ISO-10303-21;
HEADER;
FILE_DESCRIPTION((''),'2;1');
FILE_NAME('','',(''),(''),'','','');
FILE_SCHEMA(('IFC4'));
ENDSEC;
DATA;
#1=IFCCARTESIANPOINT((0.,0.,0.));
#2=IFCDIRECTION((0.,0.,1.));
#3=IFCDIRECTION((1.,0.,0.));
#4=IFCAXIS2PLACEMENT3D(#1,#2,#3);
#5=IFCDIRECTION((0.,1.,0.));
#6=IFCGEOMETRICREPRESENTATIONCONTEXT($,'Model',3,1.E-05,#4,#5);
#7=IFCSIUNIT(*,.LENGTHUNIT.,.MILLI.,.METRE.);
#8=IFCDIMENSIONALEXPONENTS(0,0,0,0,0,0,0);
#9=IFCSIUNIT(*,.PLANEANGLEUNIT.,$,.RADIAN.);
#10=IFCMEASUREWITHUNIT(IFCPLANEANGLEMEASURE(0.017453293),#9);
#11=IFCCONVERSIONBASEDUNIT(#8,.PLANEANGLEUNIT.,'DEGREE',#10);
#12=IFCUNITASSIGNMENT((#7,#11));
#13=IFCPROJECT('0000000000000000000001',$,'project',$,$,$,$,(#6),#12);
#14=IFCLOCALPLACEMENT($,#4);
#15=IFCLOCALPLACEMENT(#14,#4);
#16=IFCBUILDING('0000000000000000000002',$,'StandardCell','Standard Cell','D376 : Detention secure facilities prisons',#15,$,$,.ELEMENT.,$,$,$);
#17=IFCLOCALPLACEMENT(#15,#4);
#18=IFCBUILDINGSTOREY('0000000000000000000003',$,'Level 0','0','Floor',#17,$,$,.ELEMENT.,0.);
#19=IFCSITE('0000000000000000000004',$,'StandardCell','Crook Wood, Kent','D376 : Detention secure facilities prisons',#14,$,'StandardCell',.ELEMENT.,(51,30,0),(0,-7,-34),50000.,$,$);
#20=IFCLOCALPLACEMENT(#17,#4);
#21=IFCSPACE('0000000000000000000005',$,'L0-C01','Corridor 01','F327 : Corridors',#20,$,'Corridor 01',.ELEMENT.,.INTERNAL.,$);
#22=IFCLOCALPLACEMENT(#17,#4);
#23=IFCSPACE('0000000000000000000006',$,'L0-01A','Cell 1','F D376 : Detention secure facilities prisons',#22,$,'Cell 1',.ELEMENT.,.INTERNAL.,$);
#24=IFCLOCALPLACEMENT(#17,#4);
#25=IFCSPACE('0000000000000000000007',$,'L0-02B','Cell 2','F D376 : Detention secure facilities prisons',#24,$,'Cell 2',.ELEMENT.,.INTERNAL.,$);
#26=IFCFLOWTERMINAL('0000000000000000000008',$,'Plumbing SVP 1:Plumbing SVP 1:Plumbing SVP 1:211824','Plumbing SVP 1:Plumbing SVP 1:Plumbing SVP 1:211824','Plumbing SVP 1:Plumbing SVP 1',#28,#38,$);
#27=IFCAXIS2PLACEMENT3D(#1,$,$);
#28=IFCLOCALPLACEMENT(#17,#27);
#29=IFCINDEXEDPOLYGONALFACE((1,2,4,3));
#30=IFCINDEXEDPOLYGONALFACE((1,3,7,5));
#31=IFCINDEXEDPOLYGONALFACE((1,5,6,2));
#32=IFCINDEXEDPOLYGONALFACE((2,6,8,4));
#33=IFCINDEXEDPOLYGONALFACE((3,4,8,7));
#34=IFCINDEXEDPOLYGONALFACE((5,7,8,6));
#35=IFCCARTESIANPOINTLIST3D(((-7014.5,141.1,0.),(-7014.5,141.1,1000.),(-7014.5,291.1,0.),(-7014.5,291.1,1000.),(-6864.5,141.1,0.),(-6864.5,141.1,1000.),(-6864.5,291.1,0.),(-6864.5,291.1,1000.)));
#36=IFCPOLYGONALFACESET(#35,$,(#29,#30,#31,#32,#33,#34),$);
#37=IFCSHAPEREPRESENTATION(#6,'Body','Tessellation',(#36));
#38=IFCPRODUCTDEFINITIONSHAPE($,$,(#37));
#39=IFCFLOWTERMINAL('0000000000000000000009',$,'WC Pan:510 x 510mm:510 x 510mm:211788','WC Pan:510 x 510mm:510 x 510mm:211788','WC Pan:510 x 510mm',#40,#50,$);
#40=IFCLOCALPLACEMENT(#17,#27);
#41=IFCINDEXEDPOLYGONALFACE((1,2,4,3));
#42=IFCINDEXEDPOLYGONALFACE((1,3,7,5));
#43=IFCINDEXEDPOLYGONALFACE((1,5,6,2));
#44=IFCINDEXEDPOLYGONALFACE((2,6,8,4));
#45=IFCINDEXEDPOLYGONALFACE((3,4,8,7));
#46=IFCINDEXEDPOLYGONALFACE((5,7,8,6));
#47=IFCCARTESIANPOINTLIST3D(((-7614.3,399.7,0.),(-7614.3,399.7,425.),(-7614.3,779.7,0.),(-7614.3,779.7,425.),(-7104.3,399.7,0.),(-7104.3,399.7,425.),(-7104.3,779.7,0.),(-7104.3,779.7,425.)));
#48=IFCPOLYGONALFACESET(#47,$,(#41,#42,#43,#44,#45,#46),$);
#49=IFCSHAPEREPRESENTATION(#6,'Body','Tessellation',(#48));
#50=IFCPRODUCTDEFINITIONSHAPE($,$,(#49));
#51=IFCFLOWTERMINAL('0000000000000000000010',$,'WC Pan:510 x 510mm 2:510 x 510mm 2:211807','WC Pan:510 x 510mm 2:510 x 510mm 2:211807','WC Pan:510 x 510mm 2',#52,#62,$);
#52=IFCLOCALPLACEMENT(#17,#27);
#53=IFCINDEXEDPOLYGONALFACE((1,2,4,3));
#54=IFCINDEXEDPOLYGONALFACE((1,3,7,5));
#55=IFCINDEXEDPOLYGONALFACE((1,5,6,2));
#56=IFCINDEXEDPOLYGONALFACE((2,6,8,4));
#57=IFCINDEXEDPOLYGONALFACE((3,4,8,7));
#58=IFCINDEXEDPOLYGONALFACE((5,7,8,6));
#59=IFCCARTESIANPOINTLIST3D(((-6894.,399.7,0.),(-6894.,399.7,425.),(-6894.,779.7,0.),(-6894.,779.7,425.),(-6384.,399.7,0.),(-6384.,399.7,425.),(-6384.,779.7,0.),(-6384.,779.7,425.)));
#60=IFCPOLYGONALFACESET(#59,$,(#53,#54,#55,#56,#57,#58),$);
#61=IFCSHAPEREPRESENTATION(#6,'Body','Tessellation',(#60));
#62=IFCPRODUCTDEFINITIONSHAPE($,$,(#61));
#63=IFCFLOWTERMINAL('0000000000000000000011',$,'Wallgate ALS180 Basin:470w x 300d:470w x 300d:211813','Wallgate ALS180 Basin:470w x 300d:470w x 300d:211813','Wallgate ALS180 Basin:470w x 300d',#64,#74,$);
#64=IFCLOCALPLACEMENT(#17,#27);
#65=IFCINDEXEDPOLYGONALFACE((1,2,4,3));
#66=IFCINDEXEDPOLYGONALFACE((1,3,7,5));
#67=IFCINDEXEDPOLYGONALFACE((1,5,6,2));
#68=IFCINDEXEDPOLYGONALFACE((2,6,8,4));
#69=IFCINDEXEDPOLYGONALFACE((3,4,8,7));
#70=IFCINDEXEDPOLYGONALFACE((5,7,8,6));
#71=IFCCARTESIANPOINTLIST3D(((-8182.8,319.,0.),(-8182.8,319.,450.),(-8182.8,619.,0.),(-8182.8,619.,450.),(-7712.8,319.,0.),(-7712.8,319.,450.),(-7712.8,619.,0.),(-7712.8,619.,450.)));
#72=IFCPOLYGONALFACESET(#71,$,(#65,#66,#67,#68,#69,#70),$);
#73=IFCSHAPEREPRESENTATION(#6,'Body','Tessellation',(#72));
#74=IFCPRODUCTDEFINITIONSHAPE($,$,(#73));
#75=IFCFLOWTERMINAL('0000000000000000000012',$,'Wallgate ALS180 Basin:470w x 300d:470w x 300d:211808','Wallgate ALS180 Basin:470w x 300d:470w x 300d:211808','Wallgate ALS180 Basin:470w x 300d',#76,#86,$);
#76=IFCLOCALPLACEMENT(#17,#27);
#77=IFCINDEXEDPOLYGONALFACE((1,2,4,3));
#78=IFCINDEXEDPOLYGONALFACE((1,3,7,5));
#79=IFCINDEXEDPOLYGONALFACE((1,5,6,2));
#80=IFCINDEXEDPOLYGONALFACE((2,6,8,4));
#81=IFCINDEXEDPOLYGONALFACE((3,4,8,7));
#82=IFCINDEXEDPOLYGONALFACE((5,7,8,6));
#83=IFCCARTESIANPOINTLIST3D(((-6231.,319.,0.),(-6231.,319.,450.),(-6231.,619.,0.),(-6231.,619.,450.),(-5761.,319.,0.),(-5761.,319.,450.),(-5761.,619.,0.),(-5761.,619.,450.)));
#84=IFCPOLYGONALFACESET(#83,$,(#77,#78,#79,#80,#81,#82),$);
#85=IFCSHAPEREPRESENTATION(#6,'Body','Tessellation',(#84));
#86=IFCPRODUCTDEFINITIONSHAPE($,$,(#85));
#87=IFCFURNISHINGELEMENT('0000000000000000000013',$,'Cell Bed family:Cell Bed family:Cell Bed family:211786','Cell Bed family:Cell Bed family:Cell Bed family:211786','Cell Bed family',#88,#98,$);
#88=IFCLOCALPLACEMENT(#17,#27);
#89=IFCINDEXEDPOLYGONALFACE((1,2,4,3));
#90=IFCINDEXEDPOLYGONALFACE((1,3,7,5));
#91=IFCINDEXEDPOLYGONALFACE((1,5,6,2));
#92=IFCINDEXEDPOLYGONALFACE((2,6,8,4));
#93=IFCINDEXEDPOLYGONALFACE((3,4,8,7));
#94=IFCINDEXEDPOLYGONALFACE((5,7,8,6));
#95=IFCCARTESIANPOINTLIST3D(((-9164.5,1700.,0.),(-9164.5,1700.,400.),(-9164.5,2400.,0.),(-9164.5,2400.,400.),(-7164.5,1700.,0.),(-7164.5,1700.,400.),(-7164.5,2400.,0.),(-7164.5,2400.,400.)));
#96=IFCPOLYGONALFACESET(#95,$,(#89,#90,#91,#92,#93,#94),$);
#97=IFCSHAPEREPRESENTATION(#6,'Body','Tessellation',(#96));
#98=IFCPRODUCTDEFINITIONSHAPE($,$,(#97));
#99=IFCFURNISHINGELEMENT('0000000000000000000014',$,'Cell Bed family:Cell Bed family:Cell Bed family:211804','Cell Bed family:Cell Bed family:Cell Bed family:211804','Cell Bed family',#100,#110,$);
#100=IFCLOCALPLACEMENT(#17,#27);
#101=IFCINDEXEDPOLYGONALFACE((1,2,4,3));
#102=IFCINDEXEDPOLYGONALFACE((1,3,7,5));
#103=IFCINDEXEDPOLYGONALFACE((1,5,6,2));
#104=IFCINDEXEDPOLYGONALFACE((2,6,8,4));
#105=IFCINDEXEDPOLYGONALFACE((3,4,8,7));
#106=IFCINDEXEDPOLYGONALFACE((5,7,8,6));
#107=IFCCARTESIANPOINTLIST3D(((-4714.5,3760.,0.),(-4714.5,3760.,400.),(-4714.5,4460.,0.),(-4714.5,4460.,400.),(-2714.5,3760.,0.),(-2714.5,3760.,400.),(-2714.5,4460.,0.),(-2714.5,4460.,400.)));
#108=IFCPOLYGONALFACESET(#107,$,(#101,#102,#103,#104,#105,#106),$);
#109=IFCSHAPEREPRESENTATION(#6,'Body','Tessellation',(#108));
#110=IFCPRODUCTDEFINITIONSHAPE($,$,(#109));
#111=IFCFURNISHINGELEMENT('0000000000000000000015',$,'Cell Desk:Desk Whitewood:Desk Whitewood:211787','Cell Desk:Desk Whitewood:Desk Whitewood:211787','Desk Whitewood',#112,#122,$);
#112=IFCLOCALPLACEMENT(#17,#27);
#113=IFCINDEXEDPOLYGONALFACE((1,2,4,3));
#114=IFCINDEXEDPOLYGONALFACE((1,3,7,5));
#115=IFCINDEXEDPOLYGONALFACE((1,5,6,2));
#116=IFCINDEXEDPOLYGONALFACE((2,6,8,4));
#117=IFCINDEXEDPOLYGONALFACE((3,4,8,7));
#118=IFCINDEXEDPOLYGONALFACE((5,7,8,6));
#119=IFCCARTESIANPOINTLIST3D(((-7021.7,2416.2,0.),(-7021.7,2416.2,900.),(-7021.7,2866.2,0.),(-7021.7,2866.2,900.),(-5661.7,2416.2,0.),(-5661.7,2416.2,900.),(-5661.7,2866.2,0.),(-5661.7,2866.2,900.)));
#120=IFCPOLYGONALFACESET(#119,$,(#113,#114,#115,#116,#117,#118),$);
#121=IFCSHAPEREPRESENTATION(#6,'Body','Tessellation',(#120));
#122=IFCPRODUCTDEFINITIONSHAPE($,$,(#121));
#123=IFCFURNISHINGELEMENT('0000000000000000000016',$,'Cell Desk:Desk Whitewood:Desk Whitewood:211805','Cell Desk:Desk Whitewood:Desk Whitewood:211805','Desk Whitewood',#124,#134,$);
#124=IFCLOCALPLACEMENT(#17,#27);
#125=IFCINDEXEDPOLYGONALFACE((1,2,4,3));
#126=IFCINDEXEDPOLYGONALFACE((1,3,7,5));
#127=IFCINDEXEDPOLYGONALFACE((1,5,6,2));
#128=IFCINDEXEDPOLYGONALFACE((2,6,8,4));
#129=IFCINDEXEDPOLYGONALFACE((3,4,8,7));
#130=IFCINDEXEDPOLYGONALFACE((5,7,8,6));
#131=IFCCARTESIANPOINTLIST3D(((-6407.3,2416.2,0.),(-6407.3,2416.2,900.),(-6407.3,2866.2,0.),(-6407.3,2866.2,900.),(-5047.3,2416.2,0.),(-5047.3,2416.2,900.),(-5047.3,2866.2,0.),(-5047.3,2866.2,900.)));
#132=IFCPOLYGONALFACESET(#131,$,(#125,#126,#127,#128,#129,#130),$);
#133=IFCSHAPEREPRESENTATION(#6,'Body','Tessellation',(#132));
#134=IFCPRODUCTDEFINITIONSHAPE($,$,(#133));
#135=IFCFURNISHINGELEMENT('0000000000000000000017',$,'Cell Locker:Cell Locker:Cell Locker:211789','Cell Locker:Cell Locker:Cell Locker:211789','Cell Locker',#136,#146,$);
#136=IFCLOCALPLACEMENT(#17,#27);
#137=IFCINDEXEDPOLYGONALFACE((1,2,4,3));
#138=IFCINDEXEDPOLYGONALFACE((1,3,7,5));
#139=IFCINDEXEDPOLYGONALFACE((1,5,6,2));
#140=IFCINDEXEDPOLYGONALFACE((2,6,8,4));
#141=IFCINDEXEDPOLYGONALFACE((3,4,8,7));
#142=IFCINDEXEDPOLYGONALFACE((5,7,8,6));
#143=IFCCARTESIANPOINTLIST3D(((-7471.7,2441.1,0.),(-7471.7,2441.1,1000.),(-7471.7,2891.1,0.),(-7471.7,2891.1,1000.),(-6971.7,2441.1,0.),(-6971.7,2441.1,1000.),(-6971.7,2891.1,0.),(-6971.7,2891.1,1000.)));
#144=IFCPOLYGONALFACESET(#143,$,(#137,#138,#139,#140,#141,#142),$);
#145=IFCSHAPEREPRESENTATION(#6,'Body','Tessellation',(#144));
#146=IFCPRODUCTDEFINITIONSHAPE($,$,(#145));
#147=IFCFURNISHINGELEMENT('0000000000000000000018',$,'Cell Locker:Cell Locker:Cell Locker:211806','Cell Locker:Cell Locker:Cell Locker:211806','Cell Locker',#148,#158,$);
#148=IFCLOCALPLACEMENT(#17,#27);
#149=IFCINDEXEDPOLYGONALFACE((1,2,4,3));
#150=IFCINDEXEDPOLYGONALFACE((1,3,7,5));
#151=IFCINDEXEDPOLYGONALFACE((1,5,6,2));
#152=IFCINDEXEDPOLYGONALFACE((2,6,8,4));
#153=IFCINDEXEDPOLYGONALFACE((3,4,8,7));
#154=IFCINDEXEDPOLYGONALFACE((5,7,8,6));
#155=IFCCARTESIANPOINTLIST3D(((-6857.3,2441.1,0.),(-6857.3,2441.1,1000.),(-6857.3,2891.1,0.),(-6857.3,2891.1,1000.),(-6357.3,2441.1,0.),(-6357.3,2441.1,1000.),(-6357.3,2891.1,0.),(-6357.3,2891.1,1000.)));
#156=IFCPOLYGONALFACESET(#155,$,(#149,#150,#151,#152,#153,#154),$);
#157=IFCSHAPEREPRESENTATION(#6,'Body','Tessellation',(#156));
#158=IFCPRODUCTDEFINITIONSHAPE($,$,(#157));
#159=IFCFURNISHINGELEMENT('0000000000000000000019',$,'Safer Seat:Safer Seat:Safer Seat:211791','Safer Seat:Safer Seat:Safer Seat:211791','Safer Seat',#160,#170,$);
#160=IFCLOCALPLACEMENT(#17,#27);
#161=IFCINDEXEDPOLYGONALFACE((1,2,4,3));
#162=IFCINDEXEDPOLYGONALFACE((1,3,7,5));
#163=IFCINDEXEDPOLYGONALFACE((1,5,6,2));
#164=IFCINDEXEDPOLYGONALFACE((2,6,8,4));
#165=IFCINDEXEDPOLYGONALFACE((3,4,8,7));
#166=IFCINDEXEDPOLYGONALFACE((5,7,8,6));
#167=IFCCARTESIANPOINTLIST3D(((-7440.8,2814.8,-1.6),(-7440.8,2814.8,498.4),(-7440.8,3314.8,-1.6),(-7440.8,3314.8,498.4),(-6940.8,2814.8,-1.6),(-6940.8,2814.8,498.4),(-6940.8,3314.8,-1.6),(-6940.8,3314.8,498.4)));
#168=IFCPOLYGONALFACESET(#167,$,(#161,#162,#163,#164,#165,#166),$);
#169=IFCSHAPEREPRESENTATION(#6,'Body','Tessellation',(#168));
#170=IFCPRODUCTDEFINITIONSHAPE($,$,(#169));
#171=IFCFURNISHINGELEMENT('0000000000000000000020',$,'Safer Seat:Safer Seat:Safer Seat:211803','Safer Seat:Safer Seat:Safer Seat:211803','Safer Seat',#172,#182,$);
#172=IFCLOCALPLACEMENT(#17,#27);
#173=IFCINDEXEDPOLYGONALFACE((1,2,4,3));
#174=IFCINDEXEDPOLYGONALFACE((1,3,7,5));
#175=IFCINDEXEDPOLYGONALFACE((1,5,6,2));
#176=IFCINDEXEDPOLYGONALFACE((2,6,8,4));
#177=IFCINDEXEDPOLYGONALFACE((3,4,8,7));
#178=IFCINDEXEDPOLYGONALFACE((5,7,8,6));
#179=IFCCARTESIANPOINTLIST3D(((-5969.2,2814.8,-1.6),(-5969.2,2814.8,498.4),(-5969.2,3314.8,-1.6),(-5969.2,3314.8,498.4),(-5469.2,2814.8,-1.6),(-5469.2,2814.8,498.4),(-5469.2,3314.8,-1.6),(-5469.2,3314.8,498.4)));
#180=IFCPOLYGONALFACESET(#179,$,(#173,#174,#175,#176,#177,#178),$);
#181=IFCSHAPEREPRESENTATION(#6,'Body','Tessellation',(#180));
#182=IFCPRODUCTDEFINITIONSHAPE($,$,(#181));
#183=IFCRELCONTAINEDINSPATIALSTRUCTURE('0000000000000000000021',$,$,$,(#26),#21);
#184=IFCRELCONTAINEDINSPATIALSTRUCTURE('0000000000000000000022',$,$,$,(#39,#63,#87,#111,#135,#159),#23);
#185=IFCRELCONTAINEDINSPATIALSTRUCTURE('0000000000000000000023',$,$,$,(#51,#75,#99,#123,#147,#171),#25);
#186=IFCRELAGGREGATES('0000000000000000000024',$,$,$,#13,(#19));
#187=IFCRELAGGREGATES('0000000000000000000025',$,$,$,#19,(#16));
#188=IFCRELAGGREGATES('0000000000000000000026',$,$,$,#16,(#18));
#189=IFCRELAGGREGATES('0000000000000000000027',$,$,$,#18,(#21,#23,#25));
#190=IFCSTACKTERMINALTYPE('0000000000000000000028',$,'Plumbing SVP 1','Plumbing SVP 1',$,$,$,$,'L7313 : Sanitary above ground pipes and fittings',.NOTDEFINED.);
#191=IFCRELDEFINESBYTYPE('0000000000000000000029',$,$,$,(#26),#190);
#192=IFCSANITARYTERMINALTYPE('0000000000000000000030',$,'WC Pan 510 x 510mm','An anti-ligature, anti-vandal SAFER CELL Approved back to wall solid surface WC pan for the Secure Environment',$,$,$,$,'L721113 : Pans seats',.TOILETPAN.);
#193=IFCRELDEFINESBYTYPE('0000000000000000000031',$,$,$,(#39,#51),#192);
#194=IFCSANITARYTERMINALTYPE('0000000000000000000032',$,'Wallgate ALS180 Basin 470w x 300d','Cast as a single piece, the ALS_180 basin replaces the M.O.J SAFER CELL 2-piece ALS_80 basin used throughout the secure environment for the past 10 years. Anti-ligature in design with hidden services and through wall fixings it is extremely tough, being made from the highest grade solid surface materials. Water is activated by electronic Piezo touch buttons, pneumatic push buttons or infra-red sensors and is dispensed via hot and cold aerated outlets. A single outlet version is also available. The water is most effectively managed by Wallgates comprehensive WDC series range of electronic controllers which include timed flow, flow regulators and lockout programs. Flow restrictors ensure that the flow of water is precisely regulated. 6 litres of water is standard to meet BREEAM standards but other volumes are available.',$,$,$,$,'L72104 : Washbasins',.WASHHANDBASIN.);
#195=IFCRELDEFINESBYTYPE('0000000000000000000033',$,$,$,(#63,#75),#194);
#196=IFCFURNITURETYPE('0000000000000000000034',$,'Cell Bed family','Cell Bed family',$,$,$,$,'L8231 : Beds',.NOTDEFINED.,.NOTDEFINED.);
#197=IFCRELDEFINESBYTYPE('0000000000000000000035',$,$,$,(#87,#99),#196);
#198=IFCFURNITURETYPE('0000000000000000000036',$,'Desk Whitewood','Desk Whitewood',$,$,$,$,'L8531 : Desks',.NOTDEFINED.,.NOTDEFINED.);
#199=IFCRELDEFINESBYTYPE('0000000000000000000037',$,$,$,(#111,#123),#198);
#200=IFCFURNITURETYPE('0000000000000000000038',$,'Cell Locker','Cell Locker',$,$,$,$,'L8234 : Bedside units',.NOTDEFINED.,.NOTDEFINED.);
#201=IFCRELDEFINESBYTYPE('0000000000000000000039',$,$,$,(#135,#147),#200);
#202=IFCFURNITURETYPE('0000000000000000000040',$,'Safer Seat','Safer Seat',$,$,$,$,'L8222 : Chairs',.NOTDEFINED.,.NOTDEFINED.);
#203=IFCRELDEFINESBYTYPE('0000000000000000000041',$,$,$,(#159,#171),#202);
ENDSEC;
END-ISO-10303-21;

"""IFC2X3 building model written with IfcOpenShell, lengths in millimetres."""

from ifc_helpers import new_model, entity, si_unit, converted_unit, direction, frame, frame_2d, origin, origin_with_axes, place, context, project, spatial, rectangle, extrude, source, transform, mapped, type_object, type_shapes, element, save


model = new_model("IFC2X3")

# Units and contexts
model_context = context("Model", 3, precision=1e-05, world=origin_with_axes(), true_north=direction((0.0, 1.0, 0.0)))
ifc_project = project(units=[si_unit("LENGTHUNIT", "METRE", prefix="MILLI"), converted_unit("PLANEANGLEUNIT", "DEGREE", entity("IfcPlaneAngleMeasure", 0.017453293), si_unit("PLANEANGLEUNIT", "RADIAN"), dimensions=[0, 0, 0, 0, 0, 0, 0])], contexts=[model_context])

# Site, building, storey, space
site_placement = place(None, origin_with_axes())
site = spatial("IfcSite", under=ifc_project, at=site_placement, Name="StandardCell", Description="Crook Wood, Kent", ObjectType="D376 : Detention secure facilities prisons", LongName="StandardCell", CompositionType="ELEMENT", RefLatitude=(51, 30, 0), RefLongitude=(0, -7, -34), RefElevation=50000.0)
building_placement = place(site_placement, origin_with_axes())
building = spatial("IfcBuilding", under=site, at=building_placement, Name="StandardCell", Description="Standard Cell", ObjectType="D376 : Detention secure facilities prisons", CompositionType="ELEMENT")
storey_placement = place(building_placement, origin_with_axes())
storey = spatial("IfcBuildingStorey", under=building, at=storey_placement, Name="Level 0", Description="0", ObjectType="Floor", CompositionType="ELEMENT", Elevation=0.0)
space_1_placement = place(storey_placement, origin_with_axes())
space_1 = spatial("IfcSpace", under=storey, at=space_1_placement, Name="L0-C01", Description="Corridor 01", ObjectType="F327 : Corridors", LongName="Corridor 01", CompositionType="ELEMENT", InteriorOrExteriorSpace="INTERNAL")

# Shared definitions
space_2_placement = place(storey_placement, origin_with_axes())
space_2 = spatial("IfcSpace", under=storey, at=space_2_placement, Name="L0-01A", Description="Cell 1", ObjectType="F D376 : Detention secure facilities prisons", LongName="Cell 1", CompositionType="ELEMENT", InteriorOrExteriorSpace="INTERNAL")

# Shared definitions
space_3_placement = place(storey_placement, origin_with_axes())
space_3 = spatial("IfcSpace", under=storey, at=space_3_placement, Name="L0-02B", Description="Cell 2", ObjectType="F D376 : Detention secure facilities prisons", LongName="Cell 2", CompositionType="ELEMENT", InteriorOrExteriorSpace="INTERNAL")

# Flow terminals
stack_terminal_type = type_object("IfcStackTerminalType", Name="Plumbing SVP 1", Description="Plumbing SVP 1", ElementType="L7313 : Sanitary above ground pipes and fittings", PredefinedType="NOTDEFINED")
shared_shape_1 = source(origin(), model_context, "Body", "SweptSolid", [
    extrude(rectangle(XDim=150.0, YDim=150.0, at=frame_2d((75.0, 75.0), x_axis=(1.0, 0.0))), origin_with_axes(), (0.0, 0.0, 1.0), 1000.0),
])
type_shapes(stack_terminal_type, [shared_shape_1])
flow_terminal_1_placement = place(space_1_placement, frame((-7014.5, 141.1, 0.0), z_axis=(0.0, 0.0, 1.0), x_axis=(1.0, 0.0, 0.0)))
element("IfcFlowTerminal", 1, at=flow_terminal_1_placement, inside=space_1, type_object=stack_terminal_type, Name="Plumbing SVP 1:Plumbing SVP 1:Plumbing SVP 1:211824", Description="Plumbing SVP 1:Plumbing SVP 1:Plumbing SVP 1:211824", ObjectType="Plumbing SVP 1:Plumbing SVP 1", context=model_context, shape_type="MappedRepresentation", body=[
    mapped(shared_shape_1, transform((0.0, 0.0, 0.0))),
])
sanitary_terminal_type_1 = type_object("IfcSanitaryTerminalType", Name="WC Pan 510 x 510mm", Description="An anti-ligature, anti-vandal SAFER CELL Approved back to wall solid surface WC pan for the Secure Environment", ElementType="L721113 : Pans seats", PredefinedType="TOILETPAN")
shared_shape_2 = source(origin(), model_context, "Body", "SweptSolid", [
    extrude(rectangle(XDim=510.0, YDim=380.0, at=frame_2d((255.0, 190.0), x_axis=(1.0, 0.0))), origin_with_axes(), (0.0, 0.0, 1.0), 425.0),
])
type_shapes(sanitary_terminal_type_1, [shared_shape_2])
flow_terminal_2_placement = place(space_2_placement, frame((-7614.3, 399.7, 0.0), z_axis=(0.0, 0.0, 1.0), x_axis=(1.0, 0.0, 0.0)))
element("IfcFlowTerminal", 2, at=flow_terminal_2_placement, inside=space_2, type_object=sanitary_terminal_type_1, Name="WC Pan:510 x 510mm:510 x 510mm:211788", Description="WC Pan:510 x 510mm:510 x 510mm:211788", ObjectType="WC Pan:510 x 510mm", context=model_context, shape_type="MappedRepresentation", body=[
    mapped(shared_shape_2, transform((0.0, 0.0, 0.0))),
])
flow_terminal_3_placement = place(space_3_placement, frame((-6894.0, 399.7, 0.0), z_axis=(0.0, 0.0, 1.0), x_axis=(1.0, 0.0, 0.0)))
element("IfcFlowTerminal", 3, at=flow_terminal_3_placement, inside=space_3, type_object=sanitary_terminal_type_1, Name="WC Pan:510 x 510mm 2:510 x 510mm 2:211807", Description="WC Pan:510 x 510mm 2:510 x 510mm 2:211807", ObjectType="WC Pan:510 x 510mm 2", context=model_context, shape_type="MappedRepresentation", body=[
    mapped(shared_shape_2, transform((0.0, 0.0, 0.0))),
])
sanitary_terminal_type_2 = type_object("IfcSanitaryTerminalType", Name="Wallgate ALS180 Basin 470w x 300d", Description="Cast as a single piece, the ALS_180 basin replaces the M.O.J SAFER CELL 2-piece ALS_80 basin used throughout the secure environment for the past 10 years. Anti-ligature in design with hidden services and through wall fixings it is extremely tough, being made from the highest grade solid surface materials. Water is activated by electronic Piezo touch buttons, pneumatic push buttons or infra-red sensors and is dispensed via hot and cold aerated outlets. A single outlet version is also available. The water is most effectively managed by Wallgates comprehensive WDC series range of electronic controllers which include timed flow, flow regulators and lockout programs. Flow restrictors ensure that the flow of water is precisely regulated. 6 litres of water is standard to meet BREEAM standards but other volumes are available.", ElementType="L72104 : Washbasins", PredefinedType="WASHHANDBASIN")
shared_shape_3 = source(origin(), model_context, "Body", "SweptSolid", [
    extrude(rectangle(XDim=470.0, YDim=300.0, at=frame_2d((235.0, 150.0), x_axis=(1.0, 0.0))), origin_with_axes(), (0.0, 0.0, 1.0), 450.0),
])
type_shapes(sanitary_terminal_type_2, [shared_shape_3])
flow_terminal_4_placement = place(space_2_placement, frame((-8182.8, 319.0, 0.0), z_axis=(0.0, 0.0, 1.0), x_axis=(1.0, 0.0, 0.0)))
element("IfcFlowTerminal", 4, at=flow_terminal_4_placement, inside=space_2, type_object=sanitary_terminal_type_2, Name="Wallgate ALS180 Basin:470w x 300d:470w x 300d:211813", Description="Wallgate ALS180 Basin:470w x 300d:470w x 300d:211813", ObjectType="Wallgate ALS180 Basin:470w x 300d", context=model_context, shape_type="MappedRepresentation", body=[
    mapped(shared_shape_3, transform((0.0, 0.0, 0.0))),
])
flow_terminal_5_placement = place(space_3_placement, frame((-6231.0, 319.0, 0.0), z_axis=(0.0, 0.0, 1.0), x_axis=(1.0, 0.0, 0.0)))
element("IfcFlowTerminal", 5, at=flow_terminal_5_placement, inside=space_3, type_object=sanitary_terminal_type_2, Name="Wallgate ALS180 Basin:470w x 300d:470w x 300d:211808", Description="Wallgate ALS180 Basin:470w x 300d:470w x 300d:211808", ObjectType="Wallgate ALS180 Basin:470w x 300d", context=model_context, shape_type="MappedRepresentation", body=[
    mapped(shared_shape_3, transform((0.0, 0.0, 0.0))),
])

# Furnishing elements
furniture_type_1 = type_object("IfcFurnitureType", Name="Cell Bed family", Description="Cell Bed family", ElementType="L8231 : Beds", AssemblyPlace="NOTDEFINED")
shared_shape_4 = source(origin(), model_context, "Body", "SweptSolid", [
    extrude(rectangle(XDim=2000.0, YDim=700.0, at=frame_2d((1000.0, 350.0), x_axis=(1.0, 0.0))), origin_with_axes(), (0.0, 0.0, 1.0), 400.0),
])
type_shapes(furniture_type_1, [shared_shape_4])
furnishing_1_placement = place(space_2_placement, frame((-9164.5, 1700.0, 0.0), z_axis=(0.0, 0.0, 1.0), x_axis=(1.0, 0.0, 0.0)))
element("IfcFurnishingElement", 6, at=furnishing_1_placement, inside=space_2, type_object=furniture_type_1, Name="Cell Bed family:Cell Bed family:Cell Bed family:211786", Description="Cell Bed family:Cell Bed family:Cell Bed family:211786", ObjectType="Cell Bed family", context=model_context, shape_type="MappedRepresentation", body=[
    mapped(shared_shape_4, transform((0.0, 0.0, 0.0))),
])
furnishing_2_placement = place(space_3_placement, frame((-4714.5, 3760.0, 0.0), z_axis=(0.0, 0.0, 1.0), x_axis=(1.0, 0.0, 0.0)))
element("IfcFurnishingElement", 7, at=furnishing_2_placement, inside=space_3, type_object=furniture_type_1, Name="Cell Bed family:Cell Bed family:Cell Bed family:211804", Description="Cell Bed family:Cell Bed family:Cell Bed family:211804", ObjectType="Cell Bed family", context=model_context, shape_type="MappedRepresentation", body=[
    mapped(shared_shape_4, transform((0.0, 0.0, 0.0))),
])
furniture_type_2 = type_object("IfcFurnitureType", Name="Desk Whitewood", Description="Desk Whitewood", ElementType="L8531 : Desks", AssemblyPlace="NOTDEFINED")
shared_shape_5 = source(origin(), model_context, "Body", "SweptSolid", [
    extrude(rectangle(XDim=1360.0, YDim=450.0, at=frame_2d((680.0, 225.0), x_axis=(1.0, 0.0))), origin_with_axes(), (0.0, 0.0, 1.0), 900.0),
])
type_shapes(furniture_type_2, [shared_shape_5])
furnishing_3_placement = place(space_2_placement, frame((-7021.7, 2416.2, 0.0), z_axis=(0.0, 0.0, 1.0), x_axis=(1.0, 0.0, 0.0)))
element("IfcFurnishingElement", 8, at=furnishing_3_placement, inside=space_2, type_object=furniture_type_2, Name="Cell Desk:Desk Whitewood:Desk Whitewood:211787", Description="Cell Desk:Desk Whitewood:Desk Whitewood:211787", ObjectType="Desk Whitewood", context=model_context, shape_type="MappedRepresentation", body=[
    mapped(shared_shape_5, transform((0.0, 0.0, 0.0))),
])
furnishing_4_placement = place(space_3_placement, frame((-6407.3, 2416.2, 0.0), z_axis=(0.0, 0.0, 1.0), x_axis=(1.0, 0.0, 0.0)))
element("IfcFurnishingElement", 9, at=furnishing_4_placement, inside=space_3, type_object=furniture_type_2, Name="Cell Desk:Desk Whitewood:Desk Whitewood:211805", Description="Cell Desk:Desk Whitewood:Desk Whitewood:211805", ObjectType="Desk Whitewood", context=model_context, shape_type="MappedRepresentation", body=[
    mapped(shared_shape_5, transform((0.0, 0.0, 0.0))),
])
furniture_type_3 = type_object("IfcFurnitureType", Name="Cell Locker", Description="Cell Locker", ElementType="L8234 : Bedside units", AssemblyPlace="NOTDEFINED")
shared_shape_6 = source(origin(), model_context, "Body", "SweptSolid", [
    extrude(rectangle(XDim=500.0, YDim=450.0, at=frame_2d((250.0, 225.0), x_axis=(1.0, 0.0))), origin_with_axes(), (0.0, 0.0, 1.0), 1000.0),
])
type_shapes(furniture_type_3, [shared_shape_6])
furnishing_5_placement = place(space_2_placement, frame((-7471.7, 2441.1, 0.0), z_axis=(0.0, 0.0, 1.0), x_axis=(1.0, 0.0, 0.0)))
element("IfcFurnishingElement", 10, at=furnishing_5_placement, inside=space_2, type_object=furniture_type_3, Name="Cell Locker:Cell Locker:Cell Locker:211789", Description="Cell Locker:Cell Locker:Cell Locker:211789", ObjectType="Cell Locker", context=model_context, shape_type="MappedRepresentation", body=[
    mapped(shared_shape_6, transform((0.0, 0.0, 0.0))),
])
furnishing_6_placement = place(space_3_placement, frame((-6857.3, 2441.1, 0.0), z_axis=(0.0, 0.0, 1.0), x_axis=(1.0, 0.0, 0.0)))
element("IfcFurnishingElement", 11, at=furnishing_6_placement, inside=space_3, type_object=furniture_type_3, Name="Cell Locker:Cell Locker:Cell Locker:211806", Description="Cell Locker:Cell Locker:Cell Locker:211806", ObjectType="Cell Locker", context=model_context, shape_type="MappedRepresentation", body=[
    mapped(shared_shape_6, transform((0.0, 0.0, 0.0))),
])
furniture_type_4 = type_object("IfcFurnitureType", Name="Safer Seat", Description="Safer Seat", ElementType="L8222 : Chairs", AssemblyPlace="NOTDEFINED")
shared_shape_7 = source(origin(), model_context, "Body", "SweptSolid", [
    extrude(rectangle(XDim=500.0, YDim=500.0, at=frame_2d((250.0, 250.0), x_axis=(1.0, 0.0))), origin_with_axes(), (0.0, 0.0, 1.0), 500.0),
])
type_shapes(furniture_type_4, [shared_shape_7])
furnishing_7_placement = place(space_2_placement, frame((-7440.8, 2814.8, -1.6), z_axis=(0.0, 0.0, 1.0), x_axis=(1.0, 0.0, 0.0)))
element("IfcFurnishingElement", 12, at=furnishing_7_placement, inside=space_2, type_object=furniture_type_4, Name="Safer Seat:Safer Seat:Safer Seat:211791", Description="Safer Seat:Safer Seat:Safer Seat:211791", ObjectType="Safer Seat", context=model_context, shape_type="MappedRepresentation", body=[
    mapped(shared_shape_7, transform((0.0, 0.0, 0.0))),
])
furnishing_8_placement = place(space_3_placement, frame((-5969.2, 2814.8, -1.6), z_axis=(0.0, 0.0, 1.0), x_axis=(1.0, 0.0, 0.0)))
element("IfcFurnishingElement", 13, at=furnishing_8_placement, inside=space_3, type_object=furniture_type_4, Name="Safer Seat:Safer Seat:Safer Seat:211803", Description="Safer Seat:Safer Seat:Safer Seat:211803", ObjectType="Safer Seat", context=model_context, shape_type="MappedRepresentation", body=[
    mapped(shared_shape_7, transform((0.0, 0.0, 0.0))),
])

save(model, "model.ifc")
